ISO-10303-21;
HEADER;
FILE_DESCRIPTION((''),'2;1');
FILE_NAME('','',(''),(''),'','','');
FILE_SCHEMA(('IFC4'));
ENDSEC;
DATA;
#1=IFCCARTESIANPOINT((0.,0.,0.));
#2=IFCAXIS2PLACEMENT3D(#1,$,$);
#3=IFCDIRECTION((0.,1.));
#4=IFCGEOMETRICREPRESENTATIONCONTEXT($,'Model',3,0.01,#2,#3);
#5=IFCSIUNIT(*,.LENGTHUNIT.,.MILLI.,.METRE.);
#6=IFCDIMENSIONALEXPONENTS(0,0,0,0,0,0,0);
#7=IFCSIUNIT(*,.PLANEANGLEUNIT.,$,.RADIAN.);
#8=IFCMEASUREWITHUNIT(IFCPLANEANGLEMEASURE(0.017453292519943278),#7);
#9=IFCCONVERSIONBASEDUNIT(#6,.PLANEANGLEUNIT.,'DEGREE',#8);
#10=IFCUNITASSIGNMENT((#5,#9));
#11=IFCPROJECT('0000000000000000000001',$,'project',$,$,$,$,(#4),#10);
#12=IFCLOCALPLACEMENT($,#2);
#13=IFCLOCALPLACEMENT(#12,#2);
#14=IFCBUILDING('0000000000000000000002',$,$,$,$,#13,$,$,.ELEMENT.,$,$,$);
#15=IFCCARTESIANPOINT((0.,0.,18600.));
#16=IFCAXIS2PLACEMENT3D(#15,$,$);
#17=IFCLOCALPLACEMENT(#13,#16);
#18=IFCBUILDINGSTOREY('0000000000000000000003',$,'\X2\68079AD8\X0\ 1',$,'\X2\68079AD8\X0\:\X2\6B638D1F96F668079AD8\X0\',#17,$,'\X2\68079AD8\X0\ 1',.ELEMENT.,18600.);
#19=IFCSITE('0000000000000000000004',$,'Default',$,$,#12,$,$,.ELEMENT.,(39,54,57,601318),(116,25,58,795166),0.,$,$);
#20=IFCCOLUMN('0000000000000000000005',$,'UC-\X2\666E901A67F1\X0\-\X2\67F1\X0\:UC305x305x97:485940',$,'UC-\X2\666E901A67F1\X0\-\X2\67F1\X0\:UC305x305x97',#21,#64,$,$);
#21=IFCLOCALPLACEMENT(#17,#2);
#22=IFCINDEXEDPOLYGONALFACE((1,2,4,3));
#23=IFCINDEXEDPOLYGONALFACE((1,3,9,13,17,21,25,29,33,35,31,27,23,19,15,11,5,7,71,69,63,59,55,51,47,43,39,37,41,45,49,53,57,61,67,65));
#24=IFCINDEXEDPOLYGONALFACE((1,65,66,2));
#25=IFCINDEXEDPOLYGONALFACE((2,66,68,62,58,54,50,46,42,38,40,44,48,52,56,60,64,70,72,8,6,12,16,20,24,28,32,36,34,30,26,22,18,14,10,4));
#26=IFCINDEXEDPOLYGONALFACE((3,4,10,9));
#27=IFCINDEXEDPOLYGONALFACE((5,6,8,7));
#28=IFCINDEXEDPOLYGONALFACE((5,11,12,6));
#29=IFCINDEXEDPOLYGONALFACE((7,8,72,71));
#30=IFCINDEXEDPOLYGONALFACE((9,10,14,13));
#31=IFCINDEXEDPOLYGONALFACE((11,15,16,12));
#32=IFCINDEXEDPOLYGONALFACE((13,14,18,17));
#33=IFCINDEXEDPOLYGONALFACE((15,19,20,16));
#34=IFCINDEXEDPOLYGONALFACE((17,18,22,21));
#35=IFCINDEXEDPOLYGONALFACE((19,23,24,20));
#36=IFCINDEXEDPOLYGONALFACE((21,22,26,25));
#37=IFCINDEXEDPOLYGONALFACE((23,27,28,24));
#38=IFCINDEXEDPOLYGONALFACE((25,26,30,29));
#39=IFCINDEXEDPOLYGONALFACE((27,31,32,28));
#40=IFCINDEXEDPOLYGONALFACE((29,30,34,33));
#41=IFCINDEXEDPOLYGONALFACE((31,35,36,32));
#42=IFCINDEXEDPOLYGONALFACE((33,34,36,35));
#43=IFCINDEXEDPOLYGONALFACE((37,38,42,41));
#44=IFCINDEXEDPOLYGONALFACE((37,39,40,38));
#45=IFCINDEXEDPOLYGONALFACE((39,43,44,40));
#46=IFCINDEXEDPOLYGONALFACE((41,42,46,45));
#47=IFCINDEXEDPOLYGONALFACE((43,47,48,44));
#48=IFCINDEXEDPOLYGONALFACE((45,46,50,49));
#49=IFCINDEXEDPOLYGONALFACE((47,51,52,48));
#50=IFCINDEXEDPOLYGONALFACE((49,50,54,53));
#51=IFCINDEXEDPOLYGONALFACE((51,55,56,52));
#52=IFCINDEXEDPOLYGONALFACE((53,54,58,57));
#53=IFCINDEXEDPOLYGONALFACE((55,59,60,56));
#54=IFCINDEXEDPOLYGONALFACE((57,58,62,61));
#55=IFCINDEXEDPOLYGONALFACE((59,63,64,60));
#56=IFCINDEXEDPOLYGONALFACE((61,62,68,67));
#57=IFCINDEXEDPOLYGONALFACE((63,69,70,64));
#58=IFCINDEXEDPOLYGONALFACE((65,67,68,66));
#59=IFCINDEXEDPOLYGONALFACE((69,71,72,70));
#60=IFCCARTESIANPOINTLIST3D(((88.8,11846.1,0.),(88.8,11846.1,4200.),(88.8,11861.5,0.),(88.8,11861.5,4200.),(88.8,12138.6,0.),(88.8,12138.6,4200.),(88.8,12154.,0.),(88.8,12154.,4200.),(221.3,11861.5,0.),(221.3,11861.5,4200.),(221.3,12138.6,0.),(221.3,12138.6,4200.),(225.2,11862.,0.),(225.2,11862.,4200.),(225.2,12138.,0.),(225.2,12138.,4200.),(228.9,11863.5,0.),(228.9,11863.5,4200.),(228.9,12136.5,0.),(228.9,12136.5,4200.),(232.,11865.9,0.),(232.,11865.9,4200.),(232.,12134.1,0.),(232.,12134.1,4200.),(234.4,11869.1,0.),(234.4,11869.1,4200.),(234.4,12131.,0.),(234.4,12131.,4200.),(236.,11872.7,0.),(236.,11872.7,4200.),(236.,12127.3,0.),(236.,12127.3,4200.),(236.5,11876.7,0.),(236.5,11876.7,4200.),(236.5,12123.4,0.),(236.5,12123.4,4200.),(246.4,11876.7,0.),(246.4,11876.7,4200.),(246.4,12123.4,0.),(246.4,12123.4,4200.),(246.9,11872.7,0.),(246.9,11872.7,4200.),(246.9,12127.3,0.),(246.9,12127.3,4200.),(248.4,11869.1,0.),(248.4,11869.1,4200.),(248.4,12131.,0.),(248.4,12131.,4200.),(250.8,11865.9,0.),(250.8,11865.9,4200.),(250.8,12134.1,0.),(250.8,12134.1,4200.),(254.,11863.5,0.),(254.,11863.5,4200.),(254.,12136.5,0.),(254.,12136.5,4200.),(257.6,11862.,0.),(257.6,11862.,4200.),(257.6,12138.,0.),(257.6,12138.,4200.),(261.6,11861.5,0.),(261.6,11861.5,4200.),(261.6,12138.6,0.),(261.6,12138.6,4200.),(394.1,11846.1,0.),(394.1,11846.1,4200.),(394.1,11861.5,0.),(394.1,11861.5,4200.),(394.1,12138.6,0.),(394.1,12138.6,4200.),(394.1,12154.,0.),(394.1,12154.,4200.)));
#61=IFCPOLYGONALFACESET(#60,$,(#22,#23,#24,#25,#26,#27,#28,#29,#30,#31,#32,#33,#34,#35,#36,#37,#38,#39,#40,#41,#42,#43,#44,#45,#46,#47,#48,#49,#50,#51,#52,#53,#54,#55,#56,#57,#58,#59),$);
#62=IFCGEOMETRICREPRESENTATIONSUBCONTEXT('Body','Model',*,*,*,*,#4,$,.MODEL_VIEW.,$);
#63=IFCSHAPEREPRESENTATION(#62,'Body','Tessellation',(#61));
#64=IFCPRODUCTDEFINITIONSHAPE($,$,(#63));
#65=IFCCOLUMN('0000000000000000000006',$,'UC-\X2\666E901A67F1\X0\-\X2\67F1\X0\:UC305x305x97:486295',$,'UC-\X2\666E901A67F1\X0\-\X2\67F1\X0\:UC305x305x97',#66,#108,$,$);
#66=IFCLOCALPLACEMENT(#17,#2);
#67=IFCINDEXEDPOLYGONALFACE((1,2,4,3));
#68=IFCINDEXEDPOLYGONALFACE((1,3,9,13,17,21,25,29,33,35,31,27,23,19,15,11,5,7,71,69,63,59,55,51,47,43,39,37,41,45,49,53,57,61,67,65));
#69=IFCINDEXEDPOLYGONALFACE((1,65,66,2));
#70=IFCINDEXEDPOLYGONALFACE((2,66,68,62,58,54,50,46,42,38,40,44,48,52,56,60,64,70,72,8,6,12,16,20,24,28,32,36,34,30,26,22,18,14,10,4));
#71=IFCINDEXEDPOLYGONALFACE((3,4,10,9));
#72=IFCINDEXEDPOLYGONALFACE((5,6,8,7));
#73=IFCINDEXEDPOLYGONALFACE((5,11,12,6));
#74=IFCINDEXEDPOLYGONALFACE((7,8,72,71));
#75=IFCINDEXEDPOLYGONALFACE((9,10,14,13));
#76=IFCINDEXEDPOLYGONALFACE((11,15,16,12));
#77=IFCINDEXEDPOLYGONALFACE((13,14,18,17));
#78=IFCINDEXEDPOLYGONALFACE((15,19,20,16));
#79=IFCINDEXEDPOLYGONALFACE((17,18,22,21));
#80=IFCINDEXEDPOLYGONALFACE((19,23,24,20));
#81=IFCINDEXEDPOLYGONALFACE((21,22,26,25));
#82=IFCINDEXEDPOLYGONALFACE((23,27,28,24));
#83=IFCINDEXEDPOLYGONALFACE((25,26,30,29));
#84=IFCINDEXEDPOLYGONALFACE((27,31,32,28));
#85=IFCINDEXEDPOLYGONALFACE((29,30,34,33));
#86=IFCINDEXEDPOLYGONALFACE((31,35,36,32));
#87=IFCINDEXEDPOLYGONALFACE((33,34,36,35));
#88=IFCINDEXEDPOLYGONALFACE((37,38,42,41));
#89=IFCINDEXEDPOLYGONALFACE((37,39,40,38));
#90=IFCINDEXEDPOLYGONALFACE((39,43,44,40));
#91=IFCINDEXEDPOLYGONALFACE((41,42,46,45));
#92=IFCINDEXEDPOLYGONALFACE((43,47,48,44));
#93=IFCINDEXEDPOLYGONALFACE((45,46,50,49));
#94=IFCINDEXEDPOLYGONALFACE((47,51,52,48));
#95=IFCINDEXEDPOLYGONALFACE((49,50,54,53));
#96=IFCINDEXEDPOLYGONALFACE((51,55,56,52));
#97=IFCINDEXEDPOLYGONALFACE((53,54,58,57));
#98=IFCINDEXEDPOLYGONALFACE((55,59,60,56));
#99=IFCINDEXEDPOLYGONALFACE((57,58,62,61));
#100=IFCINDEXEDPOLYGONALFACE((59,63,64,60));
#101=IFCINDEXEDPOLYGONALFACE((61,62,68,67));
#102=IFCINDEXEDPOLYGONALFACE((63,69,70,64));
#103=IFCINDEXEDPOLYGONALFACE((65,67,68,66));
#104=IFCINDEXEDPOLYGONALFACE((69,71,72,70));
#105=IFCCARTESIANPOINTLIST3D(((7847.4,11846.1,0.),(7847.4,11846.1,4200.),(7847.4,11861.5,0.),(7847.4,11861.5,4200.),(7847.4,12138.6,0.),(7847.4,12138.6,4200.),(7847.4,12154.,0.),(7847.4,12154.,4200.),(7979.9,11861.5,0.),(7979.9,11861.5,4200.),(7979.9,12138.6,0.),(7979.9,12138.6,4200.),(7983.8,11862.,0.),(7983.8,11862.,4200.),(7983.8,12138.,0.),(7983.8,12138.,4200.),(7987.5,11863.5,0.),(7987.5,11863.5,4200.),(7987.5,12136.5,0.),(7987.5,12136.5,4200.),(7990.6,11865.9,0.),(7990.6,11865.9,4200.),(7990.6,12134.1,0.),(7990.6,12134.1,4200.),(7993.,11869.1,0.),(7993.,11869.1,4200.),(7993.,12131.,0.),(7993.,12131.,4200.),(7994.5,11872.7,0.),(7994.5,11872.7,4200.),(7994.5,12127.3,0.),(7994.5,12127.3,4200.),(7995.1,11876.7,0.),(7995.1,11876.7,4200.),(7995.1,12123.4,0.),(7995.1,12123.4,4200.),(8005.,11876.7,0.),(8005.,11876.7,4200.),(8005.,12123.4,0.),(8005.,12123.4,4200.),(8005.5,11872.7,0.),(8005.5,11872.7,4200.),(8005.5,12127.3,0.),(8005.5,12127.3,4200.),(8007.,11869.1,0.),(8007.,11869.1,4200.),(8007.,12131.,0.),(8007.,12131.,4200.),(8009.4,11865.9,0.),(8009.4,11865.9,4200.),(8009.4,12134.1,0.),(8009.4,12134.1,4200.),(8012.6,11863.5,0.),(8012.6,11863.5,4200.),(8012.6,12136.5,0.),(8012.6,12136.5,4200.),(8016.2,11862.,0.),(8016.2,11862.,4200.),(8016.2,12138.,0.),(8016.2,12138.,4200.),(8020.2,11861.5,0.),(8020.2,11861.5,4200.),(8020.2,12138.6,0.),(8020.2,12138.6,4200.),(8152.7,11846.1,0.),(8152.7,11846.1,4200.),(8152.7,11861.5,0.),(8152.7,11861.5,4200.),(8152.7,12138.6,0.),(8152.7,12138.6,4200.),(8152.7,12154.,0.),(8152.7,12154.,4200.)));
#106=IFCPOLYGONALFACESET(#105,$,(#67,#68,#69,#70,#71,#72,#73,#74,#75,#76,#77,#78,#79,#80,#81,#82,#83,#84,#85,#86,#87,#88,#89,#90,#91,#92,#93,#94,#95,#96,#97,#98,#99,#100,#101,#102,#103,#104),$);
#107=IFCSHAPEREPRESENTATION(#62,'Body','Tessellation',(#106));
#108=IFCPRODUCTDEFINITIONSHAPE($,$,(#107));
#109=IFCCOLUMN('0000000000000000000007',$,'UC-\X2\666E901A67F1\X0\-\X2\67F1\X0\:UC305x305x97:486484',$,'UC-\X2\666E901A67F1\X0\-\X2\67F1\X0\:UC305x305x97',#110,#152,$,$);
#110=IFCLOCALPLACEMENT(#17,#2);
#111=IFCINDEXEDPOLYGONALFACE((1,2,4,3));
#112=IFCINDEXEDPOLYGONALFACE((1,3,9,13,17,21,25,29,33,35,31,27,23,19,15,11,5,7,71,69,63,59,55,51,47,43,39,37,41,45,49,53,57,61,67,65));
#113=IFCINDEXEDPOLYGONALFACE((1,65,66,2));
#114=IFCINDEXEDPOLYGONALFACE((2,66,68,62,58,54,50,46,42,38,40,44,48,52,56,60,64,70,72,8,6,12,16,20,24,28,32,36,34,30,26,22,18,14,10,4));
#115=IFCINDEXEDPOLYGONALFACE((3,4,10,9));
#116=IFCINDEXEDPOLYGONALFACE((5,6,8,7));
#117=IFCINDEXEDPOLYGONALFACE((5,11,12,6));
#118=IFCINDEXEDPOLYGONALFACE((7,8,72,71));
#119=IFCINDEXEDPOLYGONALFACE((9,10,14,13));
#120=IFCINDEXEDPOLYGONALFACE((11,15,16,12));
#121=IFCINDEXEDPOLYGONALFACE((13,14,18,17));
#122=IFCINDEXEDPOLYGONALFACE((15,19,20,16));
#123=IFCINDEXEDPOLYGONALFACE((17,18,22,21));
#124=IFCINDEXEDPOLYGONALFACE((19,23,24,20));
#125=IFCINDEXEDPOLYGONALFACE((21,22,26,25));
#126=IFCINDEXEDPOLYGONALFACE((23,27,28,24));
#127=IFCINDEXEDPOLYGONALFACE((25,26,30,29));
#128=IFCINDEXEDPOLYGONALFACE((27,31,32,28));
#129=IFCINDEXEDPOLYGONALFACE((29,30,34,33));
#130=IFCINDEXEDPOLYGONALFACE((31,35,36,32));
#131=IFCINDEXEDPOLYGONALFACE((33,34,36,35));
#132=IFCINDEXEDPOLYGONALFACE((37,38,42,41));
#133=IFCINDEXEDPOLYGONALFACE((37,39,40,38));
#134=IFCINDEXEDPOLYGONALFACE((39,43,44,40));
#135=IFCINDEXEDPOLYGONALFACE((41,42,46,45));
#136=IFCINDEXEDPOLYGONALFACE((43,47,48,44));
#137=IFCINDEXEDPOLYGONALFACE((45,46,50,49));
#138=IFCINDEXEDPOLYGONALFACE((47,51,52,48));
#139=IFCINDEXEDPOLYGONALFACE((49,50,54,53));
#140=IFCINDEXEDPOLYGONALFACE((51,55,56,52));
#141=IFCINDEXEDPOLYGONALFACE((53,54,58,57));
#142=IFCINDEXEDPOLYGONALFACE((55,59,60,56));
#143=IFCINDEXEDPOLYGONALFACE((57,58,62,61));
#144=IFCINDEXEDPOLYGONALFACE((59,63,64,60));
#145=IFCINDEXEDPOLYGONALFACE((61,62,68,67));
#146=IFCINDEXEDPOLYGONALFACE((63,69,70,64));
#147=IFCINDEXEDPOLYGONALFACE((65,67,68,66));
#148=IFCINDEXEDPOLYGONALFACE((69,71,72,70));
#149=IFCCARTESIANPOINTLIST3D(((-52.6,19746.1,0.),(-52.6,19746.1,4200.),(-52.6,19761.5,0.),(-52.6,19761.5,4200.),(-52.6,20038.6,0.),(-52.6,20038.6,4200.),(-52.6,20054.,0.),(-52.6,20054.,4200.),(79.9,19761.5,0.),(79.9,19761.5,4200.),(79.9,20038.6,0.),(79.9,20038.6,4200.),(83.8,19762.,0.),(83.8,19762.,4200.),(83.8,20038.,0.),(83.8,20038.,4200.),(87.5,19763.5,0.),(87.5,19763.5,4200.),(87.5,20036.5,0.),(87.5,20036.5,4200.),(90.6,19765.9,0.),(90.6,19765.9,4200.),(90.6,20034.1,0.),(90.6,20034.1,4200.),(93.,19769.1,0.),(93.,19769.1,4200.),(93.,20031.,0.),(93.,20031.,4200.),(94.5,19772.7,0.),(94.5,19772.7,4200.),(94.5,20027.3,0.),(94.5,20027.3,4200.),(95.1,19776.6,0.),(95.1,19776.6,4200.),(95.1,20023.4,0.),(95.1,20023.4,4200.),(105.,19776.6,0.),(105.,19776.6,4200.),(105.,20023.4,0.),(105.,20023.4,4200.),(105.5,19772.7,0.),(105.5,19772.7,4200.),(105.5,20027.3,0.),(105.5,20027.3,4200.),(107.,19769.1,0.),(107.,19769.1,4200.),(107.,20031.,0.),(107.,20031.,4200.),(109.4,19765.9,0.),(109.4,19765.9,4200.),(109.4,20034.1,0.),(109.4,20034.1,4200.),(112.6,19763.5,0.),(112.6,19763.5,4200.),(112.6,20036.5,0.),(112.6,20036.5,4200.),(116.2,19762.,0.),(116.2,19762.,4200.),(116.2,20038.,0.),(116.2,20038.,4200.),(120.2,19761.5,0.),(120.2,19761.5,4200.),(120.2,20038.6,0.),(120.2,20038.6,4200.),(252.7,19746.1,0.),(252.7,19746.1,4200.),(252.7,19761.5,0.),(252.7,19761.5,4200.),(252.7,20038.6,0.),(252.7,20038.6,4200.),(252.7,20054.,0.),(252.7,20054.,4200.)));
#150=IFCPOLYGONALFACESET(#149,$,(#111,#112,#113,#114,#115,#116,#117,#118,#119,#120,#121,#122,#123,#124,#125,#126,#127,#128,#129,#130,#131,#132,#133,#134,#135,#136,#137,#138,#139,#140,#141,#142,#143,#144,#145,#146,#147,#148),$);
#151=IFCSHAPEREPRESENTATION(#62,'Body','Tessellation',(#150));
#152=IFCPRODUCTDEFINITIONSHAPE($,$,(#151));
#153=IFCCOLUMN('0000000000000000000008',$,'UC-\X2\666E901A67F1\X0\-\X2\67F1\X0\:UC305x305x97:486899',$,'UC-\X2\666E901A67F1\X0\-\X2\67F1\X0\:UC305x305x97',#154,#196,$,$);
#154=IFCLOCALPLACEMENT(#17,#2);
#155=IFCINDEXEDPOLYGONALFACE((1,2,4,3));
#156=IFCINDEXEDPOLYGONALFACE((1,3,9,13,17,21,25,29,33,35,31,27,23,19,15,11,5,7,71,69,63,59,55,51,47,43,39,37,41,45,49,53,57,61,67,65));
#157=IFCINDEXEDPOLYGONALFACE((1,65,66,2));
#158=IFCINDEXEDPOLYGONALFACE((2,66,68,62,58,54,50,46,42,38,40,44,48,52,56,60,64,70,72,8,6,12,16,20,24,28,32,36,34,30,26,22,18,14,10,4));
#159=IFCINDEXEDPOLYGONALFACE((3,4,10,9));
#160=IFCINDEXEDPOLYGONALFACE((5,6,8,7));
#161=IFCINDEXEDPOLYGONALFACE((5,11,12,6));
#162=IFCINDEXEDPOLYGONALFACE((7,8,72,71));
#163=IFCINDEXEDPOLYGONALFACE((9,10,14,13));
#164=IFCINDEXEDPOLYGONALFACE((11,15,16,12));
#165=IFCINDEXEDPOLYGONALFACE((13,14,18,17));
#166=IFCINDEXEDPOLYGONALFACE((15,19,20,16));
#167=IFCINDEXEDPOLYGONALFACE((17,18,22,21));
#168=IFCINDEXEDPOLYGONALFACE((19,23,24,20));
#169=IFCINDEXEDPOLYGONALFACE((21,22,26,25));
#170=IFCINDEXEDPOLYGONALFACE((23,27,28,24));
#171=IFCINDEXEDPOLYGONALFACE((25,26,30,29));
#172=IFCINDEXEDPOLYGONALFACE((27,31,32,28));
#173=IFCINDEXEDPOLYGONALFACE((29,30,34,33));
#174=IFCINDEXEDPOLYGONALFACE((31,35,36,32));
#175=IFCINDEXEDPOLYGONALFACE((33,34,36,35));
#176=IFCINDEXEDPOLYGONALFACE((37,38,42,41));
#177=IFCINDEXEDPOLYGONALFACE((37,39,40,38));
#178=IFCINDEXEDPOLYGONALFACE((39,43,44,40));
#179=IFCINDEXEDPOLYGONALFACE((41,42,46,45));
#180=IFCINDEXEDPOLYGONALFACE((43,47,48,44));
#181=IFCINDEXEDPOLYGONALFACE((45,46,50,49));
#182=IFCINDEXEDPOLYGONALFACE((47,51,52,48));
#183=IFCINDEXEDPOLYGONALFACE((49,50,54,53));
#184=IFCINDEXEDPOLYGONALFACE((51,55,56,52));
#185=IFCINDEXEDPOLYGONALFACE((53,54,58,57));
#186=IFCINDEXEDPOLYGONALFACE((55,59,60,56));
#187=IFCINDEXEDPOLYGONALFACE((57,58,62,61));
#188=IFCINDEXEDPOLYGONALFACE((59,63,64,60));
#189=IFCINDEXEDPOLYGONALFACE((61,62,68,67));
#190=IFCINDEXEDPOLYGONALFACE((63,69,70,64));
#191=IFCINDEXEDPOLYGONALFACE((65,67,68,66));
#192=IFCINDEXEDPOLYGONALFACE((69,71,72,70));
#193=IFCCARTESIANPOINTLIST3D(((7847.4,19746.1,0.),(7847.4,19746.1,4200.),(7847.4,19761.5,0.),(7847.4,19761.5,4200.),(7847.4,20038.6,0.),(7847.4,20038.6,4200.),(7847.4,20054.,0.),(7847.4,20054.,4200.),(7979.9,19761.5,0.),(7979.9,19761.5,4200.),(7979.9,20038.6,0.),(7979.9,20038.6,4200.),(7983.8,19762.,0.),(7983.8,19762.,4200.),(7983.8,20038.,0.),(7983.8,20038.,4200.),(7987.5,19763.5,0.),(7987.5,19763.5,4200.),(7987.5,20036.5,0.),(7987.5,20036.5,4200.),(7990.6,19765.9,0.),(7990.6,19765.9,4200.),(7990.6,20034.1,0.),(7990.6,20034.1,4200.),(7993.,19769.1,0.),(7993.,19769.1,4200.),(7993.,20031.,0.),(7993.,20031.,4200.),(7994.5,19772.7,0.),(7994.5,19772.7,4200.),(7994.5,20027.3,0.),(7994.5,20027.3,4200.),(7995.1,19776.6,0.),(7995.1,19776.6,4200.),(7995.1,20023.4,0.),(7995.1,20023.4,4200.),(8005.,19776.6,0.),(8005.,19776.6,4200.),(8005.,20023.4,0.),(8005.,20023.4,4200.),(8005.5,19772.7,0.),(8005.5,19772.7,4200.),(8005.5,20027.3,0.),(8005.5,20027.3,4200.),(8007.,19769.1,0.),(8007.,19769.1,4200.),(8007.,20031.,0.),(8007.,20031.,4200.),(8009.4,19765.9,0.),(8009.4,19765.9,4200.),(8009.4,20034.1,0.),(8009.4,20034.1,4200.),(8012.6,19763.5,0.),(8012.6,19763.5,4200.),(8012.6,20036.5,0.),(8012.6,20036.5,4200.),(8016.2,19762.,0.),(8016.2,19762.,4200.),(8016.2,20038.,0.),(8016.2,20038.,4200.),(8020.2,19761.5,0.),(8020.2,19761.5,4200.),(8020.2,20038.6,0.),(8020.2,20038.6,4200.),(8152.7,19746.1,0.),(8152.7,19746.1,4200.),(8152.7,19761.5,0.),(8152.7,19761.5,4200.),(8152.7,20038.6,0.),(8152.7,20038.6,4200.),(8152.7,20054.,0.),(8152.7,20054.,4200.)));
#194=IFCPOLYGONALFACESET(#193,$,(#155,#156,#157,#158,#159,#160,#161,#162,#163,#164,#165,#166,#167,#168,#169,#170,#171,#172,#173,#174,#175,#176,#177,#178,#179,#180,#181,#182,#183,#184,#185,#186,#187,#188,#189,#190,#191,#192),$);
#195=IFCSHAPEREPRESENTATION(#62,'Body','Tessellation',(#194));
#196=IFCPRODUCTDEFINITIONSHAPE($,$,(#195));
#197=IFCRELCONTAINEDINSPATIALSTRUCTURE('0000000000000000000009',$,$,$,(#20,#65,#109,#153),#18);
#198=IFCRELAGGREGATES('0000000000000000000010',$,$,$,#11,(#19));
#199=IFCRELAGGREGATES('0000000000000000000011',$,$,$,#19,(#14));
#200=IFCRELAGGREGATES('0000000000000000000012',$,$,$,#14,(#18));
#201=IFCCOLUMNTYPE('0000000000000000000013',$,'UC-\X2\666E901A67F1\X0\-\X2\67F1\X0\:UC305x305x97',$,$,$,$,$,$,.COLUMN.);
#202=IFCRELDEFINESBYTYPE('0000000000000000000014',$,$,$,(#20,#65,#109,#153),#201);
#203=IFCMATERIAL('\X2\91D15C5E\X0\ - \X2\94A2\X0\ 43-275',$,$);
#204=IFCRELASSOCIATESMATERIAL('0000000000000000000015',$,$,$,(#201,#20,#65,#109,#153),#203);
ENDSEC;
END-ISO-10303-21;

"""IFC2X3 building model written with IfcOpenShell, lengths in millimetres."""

from ifc_helpers import new_model, entity, si_unit, converted_unit, direction, frame, origin, origin_2d_with_axis, place, context, subcontext, project, spatial, i_section, extrude, source, transform, mapped, material, type_object, type_shapes, element, save


model = new_model("IFC2X3")

# Units and contexts
model_context = context("Model", 3, precision=0.01, world=origin(), true_north=direction((0.0, 1.0)))
body_context = subcontext(model_context, "Body", "Model", "MODEL_VIEW")
ifc_project = project(units=[si_unit("LENGTHUNIT", "METRE", prefix="MILLI"), converted_unit("PLANEANGLEUNIT", "DEGREE", entity("IfcPlaneAngleMeasure", 0.017453292519943278), si_unit("PLANEANGLEUNIT", "RADIAN"), dimensions=[0, 0, 0, 0, 0, 0, 0])], contexts=[model_context])

# Site, building, storey
site_placement = place(None, origin())
site = spatial("IfcSite", under=ifc_project, at=site_placement, Name="Default", CompositionType="ELEMENT", RefLatitude=(39, 54, 57, 601318), RefLongitude=(116, 25, 58, 795166), RefElevation=0.0)
building_placement = place(site_placement, origin())
building = spatial("IfcBuilding", under=site, at=building_placement, CompositionType="ELEMENT")
storey_placement = place(building_placement, frame((0.0, 0.0, 18600.0)))
storey = spatial("IfcBuildingStorey", under=building, at=storey_placement, Name="标高 1", ObjectType="标高:正负零标高", LongName="标高 1", CompositionType="ELEMENT", Elevation=18600.0)

# Columns
ifc_material_1 = material(Name="金属 - 钢 43-275")
column_type_1 = type_object("IfcColumnType", Name="UC-普通柱-柱:UC305x305x97", PredefinedType="COLUMN", material=ifc_material_1)
shared_shape_1 = source(origin(), body_context, "Body", "SweptSolid", [
    extrude(i_section(OverallWidth=305.3, OverallDepth=307.9, WebThickness=9.9, FlangeThickness=15.4, FilletRadius=15.2, at=origin_2d_with_axis()), frame((0.0, 0.0, 18600.0), z_axis=(0.0, 0.0, 1.0), x_axis=(-1.0, 0.0, 0.0)), (0.0, 0.0, 1.0), 4200.0),
])
type_shapes(column_type_1, [shared_shape_1])
for number, where, name in (
    (1, (241.4, 12000.0, -18600.0), "UC-普通柱-柱:UC305x305x97:485940"),
    (2, (8000.0, 12000.0, -18600.0), "UC-普通柱-柱:UC305x305x97:486295"),
    (3, (100.0, 19900.0, -18600.0), "UC-普通柱-柱:UC305x305x97:486484"),
    (4, (8000.0, 19900.0, -18600.0), "UC-普通柱-柱:UC305x305x97:486899"),
):
    element("IfcColumn", number, at=place(storey_placement, frame(where)), inside=storey, type_object=column_type_1, material=ifc_material_1, Name=name, ObjectType="UC-普通柱-柱:UC305x305x97", context=body_context, shape_type="MappedRepresentation", body=[
        mapped(shared_shape_1, transform((0.0, 0.0, 0.0), scale=1.0)),
    ])

save(model, "model.ifc")
